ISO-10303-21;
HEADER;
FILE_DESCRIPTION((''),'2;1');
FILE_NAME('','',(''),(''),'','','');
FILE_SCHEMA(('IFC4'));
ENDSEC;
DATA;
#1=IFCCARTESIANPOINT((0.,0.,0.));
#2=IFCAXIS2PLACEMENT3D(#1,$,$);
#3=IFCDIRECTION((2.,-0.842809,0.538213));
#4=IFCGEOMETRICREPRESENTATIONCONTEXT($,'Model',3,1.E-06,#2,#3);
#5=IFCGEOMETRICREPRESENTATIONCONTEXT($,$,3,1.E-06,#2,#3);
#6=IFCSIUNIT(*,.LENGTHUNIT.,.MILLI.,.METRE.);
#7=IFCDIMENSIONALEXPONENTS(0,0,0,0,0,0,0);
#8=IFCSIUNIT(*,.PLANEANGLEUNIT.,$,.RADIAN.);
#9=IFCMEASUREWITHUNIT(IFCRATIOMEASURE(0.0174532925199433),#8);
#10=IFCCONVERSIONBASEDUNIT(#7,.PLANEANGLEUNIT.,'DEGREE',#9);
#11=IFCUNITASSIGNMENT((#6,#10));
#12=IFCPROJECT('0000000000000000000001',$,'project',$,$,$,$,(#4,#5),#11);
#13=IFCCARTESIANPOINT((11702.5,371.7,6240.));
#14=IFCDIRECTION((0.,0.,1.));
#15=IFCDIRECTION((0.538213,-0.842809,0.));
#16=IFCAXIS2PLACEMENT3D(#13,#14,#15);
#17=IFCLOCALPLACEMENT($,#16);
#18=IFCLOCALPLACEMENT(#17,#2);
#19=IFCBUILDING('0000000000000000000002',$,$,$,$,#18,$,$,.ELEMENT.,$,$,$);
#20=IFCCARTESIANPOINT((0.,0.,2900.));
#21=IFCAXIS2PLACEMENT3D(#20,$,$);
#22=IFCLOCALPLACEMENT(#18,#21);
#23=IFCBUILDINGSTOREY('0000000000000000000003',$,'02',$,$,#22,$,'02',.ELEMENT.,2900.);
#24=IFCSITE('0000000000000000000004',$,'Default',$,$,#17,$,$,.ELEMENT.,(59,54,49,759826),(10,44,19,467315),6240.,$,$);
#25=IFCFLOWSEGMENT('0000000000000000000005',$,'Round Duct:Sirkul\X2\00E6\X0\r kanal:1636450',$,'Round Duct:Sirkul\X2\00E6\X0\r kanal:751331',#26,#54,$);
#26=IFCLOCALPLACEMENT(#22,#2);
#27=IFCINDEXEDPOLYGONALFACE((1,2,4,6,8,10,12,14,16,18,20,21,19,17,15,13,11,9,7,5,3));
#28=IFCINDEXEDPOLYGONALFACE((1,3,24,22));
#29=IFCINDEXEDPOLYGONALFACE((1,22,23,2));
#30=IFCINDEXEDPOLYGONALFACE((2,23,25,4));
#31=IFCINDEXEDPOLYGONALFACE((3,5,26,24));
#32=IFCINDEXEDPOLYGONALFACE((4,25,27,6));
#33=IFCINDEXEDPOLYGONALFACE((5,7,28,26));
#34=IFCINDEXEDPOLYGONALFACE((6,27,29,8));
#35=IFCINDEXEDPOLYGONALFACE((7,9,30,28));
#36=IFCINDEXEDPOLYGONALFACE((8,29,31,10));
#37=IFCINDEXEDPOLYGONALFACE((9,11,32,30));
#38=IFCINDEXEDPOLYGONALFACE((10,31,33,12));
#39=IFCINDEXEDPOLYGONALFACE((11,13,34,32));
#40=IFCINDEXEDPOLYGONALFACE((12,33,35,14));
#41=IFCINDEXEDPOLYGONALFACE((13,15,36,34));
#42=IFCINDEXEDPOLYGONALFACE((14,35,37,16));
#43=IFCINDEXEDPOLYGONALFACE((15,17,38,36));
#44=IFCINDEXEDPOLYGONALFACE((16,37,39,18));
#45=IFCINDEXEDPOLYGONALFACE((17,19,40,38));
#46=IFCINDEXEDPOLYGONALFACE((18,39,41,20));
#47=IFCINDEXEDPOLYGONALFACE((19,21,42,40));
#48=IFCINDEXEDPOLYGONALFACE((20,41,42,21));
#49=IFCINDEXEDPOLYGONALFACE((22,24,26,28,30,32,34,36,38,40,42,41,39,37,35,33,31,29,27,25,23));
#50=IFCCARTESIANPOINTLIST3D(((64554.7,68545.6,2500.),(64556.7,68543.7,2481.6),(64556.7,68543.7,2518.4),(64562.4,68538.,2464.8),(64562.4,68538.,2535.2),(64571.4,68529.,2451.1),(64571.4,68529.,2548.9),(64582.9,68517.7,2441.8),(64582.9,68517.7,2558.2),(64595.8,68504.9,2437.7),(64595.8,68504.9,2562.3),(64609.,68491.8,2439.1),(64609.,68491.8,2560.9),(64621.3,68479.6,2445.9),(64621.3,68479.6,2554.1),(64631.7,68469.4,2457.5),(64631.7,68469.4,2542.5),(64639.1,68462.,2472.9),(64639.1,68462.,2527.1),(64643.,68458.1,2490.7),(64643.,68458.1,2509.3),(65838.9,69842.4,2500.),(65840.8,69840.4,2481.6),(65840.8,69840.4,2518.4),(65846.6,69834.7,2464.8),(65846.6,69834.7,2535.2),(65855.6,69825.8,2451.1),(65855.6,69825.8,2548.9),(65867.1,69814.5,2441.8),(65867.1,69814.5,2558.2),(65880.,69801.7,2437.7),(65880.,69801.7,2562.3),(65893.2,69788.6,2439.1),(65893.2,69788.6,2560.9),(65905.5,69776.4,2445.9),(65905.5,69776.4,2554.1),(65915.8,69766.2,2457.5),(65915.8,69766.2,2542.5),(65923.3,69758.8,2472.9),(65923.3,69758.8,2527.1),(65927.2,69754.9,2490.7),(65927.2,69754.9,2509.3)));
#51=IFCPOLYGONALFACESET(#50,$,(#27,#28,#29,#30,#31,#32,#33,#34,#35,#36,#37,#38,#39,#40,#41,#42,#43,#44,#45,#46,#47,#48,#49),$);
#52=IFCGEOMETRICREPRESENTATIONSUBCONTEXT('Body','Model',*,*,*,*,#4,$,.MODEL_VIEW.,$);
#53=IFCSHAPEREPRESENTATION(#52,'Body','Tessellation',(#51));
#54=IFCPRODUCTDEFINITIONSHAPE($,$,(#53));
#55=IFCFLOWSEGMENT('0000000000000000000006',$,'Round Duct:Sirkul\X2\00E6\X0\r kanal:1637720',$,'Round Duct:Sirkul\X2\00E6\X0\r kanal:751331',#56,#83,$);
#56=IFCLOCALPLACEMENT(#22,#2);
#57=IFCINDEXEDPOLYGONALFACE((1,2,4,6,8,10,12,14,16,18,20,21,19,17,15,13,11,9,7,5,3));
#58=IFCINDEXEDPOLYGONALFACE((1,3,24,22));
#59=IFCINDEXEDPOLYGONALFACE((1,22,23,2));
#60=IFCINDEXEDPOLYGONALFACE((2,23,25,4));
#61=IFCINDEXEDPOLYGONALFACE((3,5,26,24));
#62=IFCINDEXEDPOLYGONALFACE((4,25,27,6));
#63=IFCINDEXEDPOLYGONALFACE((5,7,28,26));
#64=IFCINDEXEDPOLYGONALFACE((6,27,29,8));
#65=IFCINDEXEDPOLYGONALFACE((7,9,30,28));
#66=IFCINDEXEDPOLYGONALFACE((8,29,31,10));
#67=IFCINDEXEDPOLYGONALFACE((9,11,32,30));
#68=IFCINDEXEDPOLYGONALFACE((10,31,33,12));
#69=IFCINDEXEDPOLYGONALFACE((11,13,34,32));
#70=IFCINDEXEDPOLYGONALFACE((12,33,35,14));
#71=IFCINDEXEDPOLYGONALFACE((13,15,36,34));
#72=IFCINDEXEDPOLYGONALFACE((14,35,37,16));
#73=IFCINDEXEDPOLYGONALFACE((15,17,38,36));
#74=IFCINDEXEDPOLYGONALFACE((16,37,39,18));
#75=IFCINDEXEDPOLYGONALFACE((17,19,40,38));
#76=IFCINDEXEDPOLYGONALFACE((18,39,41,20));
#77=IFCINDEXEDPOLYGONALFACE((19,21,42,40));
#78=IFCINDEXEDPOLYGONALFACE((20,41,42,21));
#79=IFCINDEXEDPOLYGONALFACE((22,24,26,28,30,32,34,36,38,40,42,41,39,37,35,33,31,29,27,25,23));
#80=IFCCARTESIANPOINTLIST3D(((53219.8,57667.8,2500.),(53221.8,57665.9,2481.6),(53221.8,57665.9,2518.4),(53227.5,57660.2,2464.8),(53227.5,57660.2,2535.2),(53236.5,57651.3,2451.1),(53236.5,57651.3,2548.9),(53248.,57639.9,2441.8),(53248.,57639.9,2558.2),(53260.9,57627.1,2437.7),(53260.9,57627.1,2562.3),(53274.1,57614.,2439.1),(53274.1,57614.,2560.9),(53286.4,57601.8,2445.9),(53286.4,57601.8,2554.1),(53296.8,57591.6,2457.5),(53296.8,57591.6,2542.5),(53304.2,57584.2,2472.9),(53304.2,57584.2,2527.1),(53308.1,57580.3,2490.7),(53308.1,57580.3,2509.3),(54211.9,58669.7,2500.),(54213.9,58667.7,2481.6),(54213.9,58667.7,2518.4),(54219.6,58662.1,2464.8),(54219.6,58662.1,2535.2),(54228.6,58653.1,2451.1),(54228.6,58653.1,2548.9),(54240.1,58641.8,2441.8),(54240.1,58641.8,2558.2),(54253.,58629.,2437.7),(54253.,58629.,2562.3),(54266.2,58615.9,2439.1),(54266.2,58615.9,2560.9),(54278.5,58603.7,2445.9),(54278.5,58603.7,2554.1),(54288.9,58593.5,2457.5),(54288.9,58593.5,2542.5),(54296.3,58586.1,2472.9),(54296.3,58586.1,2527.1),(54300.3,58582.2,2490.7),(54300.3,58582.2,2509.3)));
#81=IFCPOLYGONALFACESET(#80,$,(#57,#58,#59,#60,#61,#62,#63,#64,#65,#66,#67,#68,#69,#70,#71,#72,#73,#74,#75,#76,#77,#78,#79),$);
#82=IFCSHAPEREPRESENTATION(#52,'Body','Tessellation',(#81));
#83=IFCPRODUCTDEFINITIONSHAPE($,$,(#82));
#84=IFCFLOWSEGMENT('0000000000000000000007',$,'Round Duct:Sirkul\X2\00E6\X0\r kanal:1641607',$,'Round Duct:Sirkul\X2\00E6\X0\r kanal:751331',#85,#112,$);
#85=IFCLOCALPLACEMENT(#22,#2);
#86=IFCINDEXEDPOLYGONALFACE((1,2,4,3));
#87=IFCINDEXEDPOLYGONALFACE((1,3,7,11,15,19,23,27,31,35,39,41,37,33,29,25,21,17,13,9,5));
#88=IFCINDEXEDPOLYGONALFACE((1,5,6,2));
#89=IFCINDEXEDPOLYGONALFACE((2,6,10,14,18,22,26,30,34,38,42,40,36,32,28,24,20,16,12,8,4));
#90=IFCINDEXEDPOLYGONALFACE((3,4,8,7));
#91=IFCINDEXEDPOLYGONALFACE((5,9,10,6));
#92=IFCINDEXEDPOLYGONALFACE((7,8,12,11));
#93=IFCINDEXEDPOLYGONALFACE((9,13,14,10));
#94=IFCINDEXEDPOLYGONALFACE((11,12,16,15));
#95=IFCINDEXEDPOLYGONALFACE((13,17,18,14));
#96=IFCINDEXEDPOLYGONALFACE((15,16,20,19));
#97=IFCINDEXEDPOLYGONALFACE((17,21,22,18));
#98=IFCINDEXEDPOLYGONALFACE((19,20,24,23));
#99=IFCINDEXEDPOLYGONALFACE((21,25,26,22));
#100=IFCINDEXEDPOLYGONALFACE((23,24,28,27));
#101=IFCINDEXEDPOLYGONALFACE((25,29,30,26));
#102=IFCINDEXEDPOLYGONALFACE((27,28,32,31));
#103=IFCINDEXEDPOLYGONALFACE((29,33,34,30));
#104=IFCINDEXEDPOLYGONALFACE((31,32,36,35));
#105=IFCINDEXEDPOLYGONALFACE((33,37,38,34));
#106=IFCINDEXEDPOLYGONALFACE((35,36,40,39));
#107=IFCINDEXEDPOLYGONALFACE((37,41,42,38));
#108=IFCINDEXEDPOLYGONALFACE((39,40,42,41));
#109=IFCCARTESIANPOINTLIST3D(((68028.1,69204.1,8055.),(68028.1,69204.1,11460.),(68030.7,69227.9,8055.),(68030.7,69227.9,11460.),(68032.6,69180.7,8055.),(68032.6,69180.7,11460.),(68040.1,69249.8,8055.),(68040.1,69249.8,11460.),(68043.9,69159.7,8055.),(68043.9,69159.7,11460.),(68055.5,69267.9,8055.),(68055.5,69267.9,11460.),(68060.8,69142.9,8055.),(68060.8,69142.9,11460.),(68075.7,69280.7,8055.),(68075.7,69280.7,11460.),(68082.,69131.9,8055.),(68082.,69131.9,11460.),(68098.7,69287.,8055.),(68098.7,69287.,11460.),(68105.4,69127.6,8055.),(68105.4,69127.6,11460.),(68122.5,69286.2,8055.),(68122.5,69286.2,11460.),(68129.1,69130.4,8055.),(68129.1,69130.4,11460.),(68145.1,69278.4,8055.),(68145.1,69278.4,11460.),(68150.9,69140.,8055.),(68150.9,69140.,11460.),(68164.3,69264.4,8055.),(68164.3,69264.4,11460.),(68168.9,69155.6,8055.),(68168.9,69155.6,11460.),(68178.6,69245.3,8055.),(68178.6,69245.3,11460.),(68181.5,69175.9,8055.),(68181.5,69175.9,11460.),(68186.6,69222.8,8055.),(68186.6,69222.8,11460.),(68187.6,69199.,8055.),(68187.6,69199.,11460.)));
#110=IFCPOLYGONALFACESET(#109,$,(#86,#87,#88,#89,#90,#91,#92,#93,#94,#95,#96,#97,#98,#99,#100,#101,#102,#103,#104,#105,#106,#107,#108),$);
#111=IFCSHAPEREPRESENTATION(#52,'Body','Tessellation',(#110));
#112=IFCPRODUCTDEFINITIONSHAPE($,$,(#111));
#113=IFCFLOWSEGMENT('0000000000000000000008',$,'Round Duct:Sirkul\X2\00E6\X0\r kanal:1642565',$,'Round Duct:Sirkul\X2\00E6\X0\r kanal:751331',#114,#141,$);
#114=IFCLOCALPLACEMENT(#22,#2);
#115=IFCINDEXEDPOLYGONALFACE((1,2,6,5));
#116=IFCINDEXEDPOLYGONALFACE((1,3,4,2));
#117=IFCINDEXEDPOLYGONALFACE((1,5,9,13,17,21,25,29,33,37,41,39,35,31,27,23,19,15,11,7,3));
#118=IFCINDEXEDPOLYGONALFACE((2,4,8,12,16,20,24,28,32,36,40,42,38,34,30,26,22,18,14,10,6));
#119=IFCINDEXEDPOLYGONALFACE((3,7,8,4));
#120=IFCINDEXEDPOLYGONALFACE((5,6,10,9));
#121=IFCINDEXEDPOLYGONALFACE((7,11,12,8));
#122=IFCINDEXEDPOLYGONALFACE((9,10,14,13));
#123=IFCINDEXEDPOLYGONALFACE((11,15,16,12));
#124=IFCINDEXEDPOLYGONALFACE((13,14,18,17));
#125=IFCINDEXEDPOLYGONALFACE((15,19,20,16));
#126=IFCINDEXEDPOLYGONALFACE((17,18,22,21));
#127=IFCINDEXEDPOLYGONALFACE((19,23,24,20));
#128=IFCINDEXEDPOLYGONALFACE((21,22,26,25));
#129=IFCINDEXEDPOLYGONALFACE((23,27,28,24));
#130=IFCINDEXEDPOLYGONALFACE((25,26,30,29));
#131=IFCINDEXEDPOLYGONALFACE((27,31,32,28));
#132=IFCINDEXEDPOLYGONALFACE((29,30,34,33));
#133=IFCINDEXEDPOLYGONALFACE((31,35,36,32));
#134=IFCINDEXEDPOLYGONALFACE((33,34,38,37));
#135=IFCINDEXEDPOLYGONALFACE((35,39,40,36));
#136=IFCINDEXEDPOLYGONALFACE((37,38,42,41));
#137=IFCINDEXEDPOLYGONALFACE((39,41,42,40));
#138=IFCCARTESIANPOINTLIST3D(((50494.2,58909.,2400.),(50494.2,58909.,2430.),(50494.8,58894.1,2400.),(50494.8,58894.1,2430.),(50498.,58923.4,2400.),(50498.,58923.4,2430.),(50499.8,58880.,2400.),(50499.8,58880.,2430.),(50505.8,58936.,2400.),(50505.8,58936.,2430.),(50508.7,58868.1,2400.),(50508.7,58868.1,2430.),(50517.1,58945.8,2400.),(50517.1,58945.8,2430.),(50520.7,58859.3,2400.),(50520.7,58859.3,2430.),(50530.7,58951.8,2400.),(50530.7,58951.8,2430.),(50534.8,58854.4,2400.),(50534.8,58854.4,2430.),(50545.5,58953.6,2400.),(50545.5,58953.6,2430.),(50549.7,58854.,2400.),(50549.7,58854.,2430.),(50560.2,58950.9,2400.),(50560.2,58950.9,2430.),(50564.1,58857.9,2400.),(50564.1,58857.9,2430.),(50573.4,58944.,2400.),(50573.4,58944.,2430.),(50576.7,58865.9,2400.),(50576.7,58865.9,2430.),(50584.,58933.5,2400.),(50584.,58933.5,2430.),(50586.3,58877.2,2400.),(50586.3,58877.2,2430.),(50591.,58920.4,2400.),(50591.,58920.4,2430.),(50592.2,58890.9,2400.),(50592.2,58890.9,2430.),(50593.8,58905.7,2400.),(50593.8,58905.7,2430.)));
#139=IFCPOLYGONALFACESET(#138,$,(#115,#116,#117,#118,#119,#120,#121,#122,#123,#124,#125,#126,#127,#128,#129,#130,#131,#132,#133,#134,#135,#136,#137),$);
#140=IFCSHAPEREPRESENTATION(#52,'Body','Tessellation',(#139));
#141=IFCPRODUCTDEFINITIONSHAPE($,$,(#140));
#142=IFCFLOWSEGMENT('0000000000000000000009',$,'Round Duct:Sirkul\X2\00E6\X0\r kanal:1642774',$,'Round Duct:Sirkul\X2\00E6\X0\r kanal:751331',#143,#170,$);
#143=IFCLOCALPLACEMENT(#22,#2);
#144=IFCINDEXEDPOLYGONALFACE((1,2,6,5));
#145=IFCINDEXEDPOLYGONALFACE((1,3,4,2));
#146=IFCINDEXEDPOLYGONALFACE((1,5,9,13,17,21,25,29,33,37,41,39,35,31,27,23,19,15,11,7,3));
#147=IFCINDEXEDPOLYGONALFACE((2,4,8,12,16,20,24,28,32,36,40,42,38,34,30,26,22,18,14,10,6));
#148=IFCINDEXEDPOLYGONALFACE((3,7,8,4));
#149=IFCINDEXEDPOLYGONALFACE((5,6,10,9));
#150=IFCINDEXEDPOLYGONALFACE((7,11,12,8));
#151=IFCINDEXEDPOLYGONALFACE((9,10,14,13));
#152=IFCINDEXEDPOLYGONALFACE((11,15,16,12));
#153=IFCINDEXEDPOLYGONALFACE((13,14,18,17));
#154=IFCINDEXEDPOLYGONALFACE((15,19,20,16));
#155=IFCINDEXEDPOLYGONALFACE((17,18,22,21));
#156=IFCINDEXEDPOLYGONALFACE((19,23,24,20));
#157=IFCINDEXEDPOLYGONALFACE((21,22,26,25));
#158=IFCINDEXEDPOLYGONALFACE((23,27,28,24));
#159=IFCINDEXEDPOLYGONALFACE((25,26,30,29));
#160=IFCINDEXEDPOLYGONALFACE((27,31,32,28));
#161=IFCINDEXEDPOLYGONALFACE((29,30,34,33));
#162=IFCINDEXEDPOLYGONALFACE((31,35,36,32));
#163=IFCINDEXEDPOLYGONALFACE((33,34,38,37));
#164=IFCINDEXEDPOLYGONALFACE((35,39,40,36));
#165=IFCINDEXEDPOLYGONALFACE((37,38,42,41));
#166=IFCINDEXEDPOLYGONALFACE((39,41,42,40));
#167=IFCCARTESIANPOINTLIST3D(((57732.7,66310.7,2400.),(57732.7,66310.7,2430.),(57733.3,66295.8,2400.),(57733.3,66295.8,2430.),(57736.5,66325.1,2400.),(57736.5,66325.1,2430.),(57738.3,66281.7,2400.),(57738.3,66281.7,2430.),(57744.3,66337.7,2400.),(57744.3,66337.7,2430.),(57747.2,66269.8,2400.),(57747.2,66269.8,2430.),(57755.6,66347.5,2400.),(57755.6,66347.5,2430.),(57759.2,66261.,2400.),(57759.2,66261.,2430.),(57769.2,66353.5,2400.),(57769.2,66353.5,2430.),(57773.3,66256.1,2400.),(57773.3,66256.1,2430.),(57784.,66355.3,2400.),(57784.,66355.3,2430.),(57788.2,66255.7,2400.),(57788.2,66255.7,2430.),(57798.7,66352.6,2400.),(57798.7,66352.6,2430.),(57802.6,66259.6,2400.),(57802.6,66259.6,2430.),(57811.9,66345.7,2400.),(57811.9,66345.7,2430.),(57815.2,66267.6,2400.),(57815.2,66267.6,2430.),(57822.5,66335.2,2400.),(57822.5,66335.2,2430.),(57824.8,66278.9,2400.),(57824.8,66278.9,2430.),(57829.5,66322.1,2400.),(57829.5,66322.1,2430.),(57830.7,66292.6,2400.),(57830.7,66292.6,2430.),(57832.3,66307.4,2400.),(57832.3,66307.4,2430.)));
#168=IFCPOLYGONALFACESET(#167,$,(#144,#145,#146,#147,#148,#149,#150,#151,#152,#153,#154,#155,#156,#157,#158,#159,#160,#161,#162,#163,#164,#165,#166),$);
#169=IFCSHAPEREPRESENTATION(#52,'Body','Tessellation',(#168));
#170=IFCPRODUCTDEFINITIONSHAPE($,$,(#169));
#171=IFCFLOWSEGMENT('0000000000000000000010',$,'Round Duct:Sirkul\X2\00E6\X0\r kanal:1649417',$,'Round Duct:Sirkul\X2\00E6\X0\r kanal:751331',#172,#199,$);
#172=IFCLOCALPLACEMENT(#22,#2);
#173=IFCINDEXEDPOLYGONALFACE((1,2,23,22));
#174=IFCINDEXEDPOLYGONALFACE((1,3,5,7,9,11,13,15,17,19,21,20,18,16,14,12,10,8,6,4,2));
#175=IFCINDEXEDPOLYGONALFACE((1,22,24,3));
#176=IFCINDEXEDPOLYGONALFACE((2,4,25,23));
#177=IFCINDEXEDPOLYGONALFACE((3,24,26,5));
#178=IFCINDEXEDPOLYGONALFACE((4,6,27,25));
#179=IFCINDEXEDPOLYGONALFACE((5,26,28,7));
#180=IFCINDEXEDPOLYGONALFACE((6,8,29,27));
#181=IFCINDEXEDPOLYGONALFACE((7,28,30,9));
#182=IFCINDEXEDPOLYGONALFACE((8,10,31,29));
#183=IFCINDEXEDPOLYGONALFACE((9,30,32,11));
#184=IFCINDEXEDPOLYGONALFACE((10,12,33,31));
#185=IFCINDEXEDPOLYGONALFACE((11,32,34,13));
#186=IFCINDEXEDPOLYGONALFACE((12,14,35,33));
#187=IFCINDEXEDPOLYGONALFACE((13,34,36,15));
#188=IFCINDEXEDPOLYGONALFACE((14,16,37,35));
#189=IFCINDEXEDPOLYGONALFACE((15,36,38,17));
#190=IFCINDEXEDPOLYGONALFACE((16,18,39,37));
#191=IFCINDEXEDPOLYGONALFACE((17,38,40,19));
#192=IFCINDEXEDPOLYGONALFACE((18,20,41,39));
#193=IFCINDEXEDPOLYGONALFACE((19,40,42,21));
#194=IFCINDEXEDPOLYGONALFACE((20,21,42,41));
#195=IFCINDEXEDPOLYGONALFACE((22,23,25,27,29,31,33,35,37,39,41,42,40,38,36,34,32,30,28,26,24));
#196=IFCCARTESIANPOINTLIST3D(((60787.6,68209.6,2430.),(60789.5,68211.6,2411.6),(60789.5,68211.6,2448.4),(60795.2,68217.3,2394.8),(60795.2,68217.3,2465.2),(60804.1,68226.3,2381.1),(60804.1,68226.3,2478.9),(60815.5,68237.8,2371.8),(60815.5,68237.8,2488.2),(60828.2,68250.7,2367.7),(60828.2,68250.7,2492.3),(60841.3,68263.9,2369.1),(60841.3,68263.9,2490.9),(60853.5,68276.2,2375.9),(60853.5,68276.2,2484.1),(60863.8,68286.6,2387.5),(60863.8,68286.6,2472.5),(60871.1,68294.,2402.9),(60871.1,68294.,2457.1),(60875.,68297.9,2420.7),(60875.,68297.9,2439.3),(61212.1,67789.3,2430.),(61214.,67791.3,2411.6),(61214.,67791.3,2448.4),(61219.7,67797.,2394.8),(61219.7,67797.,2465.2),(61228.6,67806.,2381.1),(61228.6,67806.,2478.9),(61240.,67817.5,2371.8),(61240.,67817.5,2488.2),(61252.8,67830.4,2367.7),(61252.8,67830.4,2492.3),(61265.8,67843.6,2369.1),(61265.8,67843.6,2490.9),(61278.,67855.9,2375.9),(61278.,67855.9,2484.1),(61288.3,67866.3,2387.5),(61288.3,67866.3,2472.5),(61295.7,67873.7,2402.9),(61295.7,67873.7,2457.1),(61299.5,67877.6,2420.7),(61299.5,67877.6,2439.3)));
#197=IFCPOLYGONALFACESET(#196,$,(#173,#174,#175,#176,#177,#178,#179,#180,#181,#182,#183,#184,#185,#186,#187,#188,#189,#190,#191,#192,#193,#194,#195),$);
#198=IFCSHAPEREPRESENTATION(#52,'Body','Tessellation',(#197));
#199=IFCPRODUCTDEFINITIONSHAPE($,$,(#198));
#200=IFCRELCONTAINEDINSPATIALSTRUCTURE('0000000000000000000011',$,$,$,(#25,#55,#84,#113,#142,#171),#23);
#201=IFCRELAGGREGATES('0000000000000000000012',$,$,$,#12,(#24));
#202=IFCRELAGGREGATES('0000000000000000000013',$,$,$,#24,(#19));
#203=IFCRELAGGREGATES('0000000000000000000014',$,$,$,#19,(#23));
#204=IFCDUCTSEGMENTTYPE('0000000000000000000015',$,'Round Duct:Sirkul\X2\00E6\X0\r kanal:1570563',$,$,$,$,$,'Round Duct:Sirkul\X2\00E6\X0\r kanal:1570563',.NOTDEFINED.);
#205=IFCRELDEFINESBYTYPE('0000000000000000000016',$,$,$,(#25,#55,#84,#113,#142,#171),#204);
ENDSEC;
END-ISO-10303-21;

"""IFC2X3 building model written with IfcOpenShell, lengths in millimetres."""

from ifc_helpers import new_model, entity, si_unit, converted_unit, direction, frame, frame_2d, origin, origin_2d_with_axis, place, context, subcontext, project, spatial, circle, extrude, type_object, element, save


model = new_model("IFC2X3")

# Units and contexts
model_context = context("Model", 3, precision=1e-06, world=origin(), true_north=direction((2.0, -0.842809, 0.538213)))
context_of_model = context(None, 3, precision=1e-06, world=origin(), true_north=direction((2.0, -0.842809, 0.538213)))
body_context = subcontext(model_context, "Body", "Model", "MODEL_VIEW")
ifc_project = project(units=[si_unit("LENGTHUNIT", "METRE", prefix="MILLI"), converted_unit("PLANEANGLEUNIT", "DEGREE", entity("IfcRatioMeasure", 0.0174532925199433), si_unit("PLANEANGLEUNIT", "RADIAN"), dimensions=[0, 0, 0, 0, 0, 0, 0])], contexts=[model_context, context_of_model])

# Site, building, storey
site_placement = place(None, frame((11702.5, 371.7, 6240.0), z_axis=(0.0, 0.0, 1.0), x_axis=(0.538213, -0.842809, 0.0)))
site = spatial("IfcSite", under=ifc_project, at=site_placement, Name="Default", CompositionType="ELEMENT", RefLatitude=(59, 54, 49, 759826), RefLongitude=(10, 44, 19, 467315), RefElevation=6240.0)
building_placement = place(site_placement, origin())
building = spatial("IfcBuilding", under=site, at=building_placement, CompositionType="ELEMENT")
storey_placement = place(building_placement, frame((0.0, 0.0, 2900.0)))
storey = spatial("IfcBuildingStorey", under=building, at=storey_placement, Name="02", LongName="02", CompositionType="ELEMENT", Elevation=2900.0)

# Flow segments
duct_segment_type = type_object("IfcDuctSegmentType", Name="Round Duct:Sirkulær kanal:1570563", ElementType="Round Duct:Sirkulær kanal:1570563", PredefinedType="NOTDEFINED")
flow_segment_1_placement = place(storey_placement, origin())
element("IfcFlowSegment", 1, at=flow_segment_1_placement, inside=storey, type_object=duct_segment_type, Name="Round Duct:Sirkulær kanal:1636450", ObjectType="Round Duct:Sirkulær kanal:751331", context=body_context, shape_type="SweptSolid", body=[
    extrude(circle(Radius=62.5, at=origin_2d_with_axis()), frame((64599.1, 68501.6, 2500.0), z_axis=(0.703643, 0.710554, 0.0), x_axis=(-0.710554, 0.703643, 0.0)), (0.0, 0.0, 1.0), 1825.0),
])
flow_segment_2_placement = place(storey_placement, origin())
element("IfcFlowSegment", 2, at=flow_segment_2_placement, inside=storey, type_object=duct_segment_type, Name="Round Duct:Sirkulær kanal:1637720", ObjectType="Round Duct:Sirkulær kanal:751331", context=body_context, shape_type="SweptSolid", body=[
    extrude(circle(Radius=62.5, at=frame_2d((0.0, 0.0), x_axis=(1.0, 0.0))), frame((53264.2, 57623.8, 2500.0), z_axis=(0.703643, 0.710554, 0.0), x_axis=(-0.710554, 0.703643, 0.0)), (0.0, 0.0, 1.0), 1410.0),
])
flow_segment_3_placement = place(storey_placement, origin())
element("IfcFlowSegment", 3, at=flow_segment_3_placement, inside=storey, type_object=duct_segment_type, Name="Round Duct:Sirkulær kanal:1641607", ObjectType="Round Duct:Sirkulær kanal:751331", context=body_context, shape_type="SweptSolid", body=[
    extrude(circle(Radius=80.0, at=frame_2d((0.0, 0.0), x_axis=(1.0, 0.0))), frame((68108.0, 69207.5, 8055.0), z_axis=(0.0, 0.0, 1.0), x_axis=(0.703643, 0.710554, 0.0)), (0.0, 0.0, 1.0), 3405.0),
])
flow_segment_4_placement = place(storey_placement, origin())
element("IfcFlowSegment", 4, at=flow_segment_4_placement, inside=storey, type_object=duct_segment_type, Name="Round Duct:Sirkulær kanal:1642565", ObjectType="Round Duct:Sirkulær kanal:751331", context=body_context, shape_type="SweptSolid", body=[
    extrude(circle(Radius=50.0, at=frame_2d((0.0, 0.0), x_axis=(1.0, 0.0))), frame((50543.9, 58903.6, 2400.0), z_axis=(0.0, 0.0, 1.0), x_axis=(-0.703643, -0.710554, 0.0)), (0.0, 0.0, 1.0), 30.0),
])
flow_segment_5_placement = place(storey_placement, origin())
element("IfcFlowSegment", 5, at=flow_segment_5_placement, inside=storey, type_object=duct_segment_type, Name="Round Duct:Sirkulær kanal:1642774", ObjectType="Round Duct:Sirkulær kanal:751331", context=body_context, shape_type="SweptSolid", body=[
    extrude(circle(Radius=50.0, at=frame_2d((0.0, 0.0), x_axis=(1.0, 0.0))), frame((57782.4, 66305.3, 2400.0), z_axis=(0.0, 0.0, 1.0), x_axis=(-0.703643, -0.710554, 0.0)), (0.0, 0.0, 1.0), 30.0),
])
flow_segment_6_placement = place(storey_placement, origin())
element("IfcFlowSegment", 6, at=flow_segment_6_placement, inside=storey, type_object=duct_segment_type, Name="Round Duct:Sirkulær kanal:1649417", ObjectType="Round Duct:Sirkulær kanal:751331", context=body_context, shape_type="SweptSolid", body=[
    extrude(circle(Radius=62.5, at=origin_2d_with_axis()), frame((60831.5, 68254.0, 2430.0), z_axis=(0.710601, -0.703596, 0.0), x_axis=(-0.703596, -0.710601, 0.0)), (0.0, 0.0, 1.0), 597.4),
])

save(model, "model.ifc")
